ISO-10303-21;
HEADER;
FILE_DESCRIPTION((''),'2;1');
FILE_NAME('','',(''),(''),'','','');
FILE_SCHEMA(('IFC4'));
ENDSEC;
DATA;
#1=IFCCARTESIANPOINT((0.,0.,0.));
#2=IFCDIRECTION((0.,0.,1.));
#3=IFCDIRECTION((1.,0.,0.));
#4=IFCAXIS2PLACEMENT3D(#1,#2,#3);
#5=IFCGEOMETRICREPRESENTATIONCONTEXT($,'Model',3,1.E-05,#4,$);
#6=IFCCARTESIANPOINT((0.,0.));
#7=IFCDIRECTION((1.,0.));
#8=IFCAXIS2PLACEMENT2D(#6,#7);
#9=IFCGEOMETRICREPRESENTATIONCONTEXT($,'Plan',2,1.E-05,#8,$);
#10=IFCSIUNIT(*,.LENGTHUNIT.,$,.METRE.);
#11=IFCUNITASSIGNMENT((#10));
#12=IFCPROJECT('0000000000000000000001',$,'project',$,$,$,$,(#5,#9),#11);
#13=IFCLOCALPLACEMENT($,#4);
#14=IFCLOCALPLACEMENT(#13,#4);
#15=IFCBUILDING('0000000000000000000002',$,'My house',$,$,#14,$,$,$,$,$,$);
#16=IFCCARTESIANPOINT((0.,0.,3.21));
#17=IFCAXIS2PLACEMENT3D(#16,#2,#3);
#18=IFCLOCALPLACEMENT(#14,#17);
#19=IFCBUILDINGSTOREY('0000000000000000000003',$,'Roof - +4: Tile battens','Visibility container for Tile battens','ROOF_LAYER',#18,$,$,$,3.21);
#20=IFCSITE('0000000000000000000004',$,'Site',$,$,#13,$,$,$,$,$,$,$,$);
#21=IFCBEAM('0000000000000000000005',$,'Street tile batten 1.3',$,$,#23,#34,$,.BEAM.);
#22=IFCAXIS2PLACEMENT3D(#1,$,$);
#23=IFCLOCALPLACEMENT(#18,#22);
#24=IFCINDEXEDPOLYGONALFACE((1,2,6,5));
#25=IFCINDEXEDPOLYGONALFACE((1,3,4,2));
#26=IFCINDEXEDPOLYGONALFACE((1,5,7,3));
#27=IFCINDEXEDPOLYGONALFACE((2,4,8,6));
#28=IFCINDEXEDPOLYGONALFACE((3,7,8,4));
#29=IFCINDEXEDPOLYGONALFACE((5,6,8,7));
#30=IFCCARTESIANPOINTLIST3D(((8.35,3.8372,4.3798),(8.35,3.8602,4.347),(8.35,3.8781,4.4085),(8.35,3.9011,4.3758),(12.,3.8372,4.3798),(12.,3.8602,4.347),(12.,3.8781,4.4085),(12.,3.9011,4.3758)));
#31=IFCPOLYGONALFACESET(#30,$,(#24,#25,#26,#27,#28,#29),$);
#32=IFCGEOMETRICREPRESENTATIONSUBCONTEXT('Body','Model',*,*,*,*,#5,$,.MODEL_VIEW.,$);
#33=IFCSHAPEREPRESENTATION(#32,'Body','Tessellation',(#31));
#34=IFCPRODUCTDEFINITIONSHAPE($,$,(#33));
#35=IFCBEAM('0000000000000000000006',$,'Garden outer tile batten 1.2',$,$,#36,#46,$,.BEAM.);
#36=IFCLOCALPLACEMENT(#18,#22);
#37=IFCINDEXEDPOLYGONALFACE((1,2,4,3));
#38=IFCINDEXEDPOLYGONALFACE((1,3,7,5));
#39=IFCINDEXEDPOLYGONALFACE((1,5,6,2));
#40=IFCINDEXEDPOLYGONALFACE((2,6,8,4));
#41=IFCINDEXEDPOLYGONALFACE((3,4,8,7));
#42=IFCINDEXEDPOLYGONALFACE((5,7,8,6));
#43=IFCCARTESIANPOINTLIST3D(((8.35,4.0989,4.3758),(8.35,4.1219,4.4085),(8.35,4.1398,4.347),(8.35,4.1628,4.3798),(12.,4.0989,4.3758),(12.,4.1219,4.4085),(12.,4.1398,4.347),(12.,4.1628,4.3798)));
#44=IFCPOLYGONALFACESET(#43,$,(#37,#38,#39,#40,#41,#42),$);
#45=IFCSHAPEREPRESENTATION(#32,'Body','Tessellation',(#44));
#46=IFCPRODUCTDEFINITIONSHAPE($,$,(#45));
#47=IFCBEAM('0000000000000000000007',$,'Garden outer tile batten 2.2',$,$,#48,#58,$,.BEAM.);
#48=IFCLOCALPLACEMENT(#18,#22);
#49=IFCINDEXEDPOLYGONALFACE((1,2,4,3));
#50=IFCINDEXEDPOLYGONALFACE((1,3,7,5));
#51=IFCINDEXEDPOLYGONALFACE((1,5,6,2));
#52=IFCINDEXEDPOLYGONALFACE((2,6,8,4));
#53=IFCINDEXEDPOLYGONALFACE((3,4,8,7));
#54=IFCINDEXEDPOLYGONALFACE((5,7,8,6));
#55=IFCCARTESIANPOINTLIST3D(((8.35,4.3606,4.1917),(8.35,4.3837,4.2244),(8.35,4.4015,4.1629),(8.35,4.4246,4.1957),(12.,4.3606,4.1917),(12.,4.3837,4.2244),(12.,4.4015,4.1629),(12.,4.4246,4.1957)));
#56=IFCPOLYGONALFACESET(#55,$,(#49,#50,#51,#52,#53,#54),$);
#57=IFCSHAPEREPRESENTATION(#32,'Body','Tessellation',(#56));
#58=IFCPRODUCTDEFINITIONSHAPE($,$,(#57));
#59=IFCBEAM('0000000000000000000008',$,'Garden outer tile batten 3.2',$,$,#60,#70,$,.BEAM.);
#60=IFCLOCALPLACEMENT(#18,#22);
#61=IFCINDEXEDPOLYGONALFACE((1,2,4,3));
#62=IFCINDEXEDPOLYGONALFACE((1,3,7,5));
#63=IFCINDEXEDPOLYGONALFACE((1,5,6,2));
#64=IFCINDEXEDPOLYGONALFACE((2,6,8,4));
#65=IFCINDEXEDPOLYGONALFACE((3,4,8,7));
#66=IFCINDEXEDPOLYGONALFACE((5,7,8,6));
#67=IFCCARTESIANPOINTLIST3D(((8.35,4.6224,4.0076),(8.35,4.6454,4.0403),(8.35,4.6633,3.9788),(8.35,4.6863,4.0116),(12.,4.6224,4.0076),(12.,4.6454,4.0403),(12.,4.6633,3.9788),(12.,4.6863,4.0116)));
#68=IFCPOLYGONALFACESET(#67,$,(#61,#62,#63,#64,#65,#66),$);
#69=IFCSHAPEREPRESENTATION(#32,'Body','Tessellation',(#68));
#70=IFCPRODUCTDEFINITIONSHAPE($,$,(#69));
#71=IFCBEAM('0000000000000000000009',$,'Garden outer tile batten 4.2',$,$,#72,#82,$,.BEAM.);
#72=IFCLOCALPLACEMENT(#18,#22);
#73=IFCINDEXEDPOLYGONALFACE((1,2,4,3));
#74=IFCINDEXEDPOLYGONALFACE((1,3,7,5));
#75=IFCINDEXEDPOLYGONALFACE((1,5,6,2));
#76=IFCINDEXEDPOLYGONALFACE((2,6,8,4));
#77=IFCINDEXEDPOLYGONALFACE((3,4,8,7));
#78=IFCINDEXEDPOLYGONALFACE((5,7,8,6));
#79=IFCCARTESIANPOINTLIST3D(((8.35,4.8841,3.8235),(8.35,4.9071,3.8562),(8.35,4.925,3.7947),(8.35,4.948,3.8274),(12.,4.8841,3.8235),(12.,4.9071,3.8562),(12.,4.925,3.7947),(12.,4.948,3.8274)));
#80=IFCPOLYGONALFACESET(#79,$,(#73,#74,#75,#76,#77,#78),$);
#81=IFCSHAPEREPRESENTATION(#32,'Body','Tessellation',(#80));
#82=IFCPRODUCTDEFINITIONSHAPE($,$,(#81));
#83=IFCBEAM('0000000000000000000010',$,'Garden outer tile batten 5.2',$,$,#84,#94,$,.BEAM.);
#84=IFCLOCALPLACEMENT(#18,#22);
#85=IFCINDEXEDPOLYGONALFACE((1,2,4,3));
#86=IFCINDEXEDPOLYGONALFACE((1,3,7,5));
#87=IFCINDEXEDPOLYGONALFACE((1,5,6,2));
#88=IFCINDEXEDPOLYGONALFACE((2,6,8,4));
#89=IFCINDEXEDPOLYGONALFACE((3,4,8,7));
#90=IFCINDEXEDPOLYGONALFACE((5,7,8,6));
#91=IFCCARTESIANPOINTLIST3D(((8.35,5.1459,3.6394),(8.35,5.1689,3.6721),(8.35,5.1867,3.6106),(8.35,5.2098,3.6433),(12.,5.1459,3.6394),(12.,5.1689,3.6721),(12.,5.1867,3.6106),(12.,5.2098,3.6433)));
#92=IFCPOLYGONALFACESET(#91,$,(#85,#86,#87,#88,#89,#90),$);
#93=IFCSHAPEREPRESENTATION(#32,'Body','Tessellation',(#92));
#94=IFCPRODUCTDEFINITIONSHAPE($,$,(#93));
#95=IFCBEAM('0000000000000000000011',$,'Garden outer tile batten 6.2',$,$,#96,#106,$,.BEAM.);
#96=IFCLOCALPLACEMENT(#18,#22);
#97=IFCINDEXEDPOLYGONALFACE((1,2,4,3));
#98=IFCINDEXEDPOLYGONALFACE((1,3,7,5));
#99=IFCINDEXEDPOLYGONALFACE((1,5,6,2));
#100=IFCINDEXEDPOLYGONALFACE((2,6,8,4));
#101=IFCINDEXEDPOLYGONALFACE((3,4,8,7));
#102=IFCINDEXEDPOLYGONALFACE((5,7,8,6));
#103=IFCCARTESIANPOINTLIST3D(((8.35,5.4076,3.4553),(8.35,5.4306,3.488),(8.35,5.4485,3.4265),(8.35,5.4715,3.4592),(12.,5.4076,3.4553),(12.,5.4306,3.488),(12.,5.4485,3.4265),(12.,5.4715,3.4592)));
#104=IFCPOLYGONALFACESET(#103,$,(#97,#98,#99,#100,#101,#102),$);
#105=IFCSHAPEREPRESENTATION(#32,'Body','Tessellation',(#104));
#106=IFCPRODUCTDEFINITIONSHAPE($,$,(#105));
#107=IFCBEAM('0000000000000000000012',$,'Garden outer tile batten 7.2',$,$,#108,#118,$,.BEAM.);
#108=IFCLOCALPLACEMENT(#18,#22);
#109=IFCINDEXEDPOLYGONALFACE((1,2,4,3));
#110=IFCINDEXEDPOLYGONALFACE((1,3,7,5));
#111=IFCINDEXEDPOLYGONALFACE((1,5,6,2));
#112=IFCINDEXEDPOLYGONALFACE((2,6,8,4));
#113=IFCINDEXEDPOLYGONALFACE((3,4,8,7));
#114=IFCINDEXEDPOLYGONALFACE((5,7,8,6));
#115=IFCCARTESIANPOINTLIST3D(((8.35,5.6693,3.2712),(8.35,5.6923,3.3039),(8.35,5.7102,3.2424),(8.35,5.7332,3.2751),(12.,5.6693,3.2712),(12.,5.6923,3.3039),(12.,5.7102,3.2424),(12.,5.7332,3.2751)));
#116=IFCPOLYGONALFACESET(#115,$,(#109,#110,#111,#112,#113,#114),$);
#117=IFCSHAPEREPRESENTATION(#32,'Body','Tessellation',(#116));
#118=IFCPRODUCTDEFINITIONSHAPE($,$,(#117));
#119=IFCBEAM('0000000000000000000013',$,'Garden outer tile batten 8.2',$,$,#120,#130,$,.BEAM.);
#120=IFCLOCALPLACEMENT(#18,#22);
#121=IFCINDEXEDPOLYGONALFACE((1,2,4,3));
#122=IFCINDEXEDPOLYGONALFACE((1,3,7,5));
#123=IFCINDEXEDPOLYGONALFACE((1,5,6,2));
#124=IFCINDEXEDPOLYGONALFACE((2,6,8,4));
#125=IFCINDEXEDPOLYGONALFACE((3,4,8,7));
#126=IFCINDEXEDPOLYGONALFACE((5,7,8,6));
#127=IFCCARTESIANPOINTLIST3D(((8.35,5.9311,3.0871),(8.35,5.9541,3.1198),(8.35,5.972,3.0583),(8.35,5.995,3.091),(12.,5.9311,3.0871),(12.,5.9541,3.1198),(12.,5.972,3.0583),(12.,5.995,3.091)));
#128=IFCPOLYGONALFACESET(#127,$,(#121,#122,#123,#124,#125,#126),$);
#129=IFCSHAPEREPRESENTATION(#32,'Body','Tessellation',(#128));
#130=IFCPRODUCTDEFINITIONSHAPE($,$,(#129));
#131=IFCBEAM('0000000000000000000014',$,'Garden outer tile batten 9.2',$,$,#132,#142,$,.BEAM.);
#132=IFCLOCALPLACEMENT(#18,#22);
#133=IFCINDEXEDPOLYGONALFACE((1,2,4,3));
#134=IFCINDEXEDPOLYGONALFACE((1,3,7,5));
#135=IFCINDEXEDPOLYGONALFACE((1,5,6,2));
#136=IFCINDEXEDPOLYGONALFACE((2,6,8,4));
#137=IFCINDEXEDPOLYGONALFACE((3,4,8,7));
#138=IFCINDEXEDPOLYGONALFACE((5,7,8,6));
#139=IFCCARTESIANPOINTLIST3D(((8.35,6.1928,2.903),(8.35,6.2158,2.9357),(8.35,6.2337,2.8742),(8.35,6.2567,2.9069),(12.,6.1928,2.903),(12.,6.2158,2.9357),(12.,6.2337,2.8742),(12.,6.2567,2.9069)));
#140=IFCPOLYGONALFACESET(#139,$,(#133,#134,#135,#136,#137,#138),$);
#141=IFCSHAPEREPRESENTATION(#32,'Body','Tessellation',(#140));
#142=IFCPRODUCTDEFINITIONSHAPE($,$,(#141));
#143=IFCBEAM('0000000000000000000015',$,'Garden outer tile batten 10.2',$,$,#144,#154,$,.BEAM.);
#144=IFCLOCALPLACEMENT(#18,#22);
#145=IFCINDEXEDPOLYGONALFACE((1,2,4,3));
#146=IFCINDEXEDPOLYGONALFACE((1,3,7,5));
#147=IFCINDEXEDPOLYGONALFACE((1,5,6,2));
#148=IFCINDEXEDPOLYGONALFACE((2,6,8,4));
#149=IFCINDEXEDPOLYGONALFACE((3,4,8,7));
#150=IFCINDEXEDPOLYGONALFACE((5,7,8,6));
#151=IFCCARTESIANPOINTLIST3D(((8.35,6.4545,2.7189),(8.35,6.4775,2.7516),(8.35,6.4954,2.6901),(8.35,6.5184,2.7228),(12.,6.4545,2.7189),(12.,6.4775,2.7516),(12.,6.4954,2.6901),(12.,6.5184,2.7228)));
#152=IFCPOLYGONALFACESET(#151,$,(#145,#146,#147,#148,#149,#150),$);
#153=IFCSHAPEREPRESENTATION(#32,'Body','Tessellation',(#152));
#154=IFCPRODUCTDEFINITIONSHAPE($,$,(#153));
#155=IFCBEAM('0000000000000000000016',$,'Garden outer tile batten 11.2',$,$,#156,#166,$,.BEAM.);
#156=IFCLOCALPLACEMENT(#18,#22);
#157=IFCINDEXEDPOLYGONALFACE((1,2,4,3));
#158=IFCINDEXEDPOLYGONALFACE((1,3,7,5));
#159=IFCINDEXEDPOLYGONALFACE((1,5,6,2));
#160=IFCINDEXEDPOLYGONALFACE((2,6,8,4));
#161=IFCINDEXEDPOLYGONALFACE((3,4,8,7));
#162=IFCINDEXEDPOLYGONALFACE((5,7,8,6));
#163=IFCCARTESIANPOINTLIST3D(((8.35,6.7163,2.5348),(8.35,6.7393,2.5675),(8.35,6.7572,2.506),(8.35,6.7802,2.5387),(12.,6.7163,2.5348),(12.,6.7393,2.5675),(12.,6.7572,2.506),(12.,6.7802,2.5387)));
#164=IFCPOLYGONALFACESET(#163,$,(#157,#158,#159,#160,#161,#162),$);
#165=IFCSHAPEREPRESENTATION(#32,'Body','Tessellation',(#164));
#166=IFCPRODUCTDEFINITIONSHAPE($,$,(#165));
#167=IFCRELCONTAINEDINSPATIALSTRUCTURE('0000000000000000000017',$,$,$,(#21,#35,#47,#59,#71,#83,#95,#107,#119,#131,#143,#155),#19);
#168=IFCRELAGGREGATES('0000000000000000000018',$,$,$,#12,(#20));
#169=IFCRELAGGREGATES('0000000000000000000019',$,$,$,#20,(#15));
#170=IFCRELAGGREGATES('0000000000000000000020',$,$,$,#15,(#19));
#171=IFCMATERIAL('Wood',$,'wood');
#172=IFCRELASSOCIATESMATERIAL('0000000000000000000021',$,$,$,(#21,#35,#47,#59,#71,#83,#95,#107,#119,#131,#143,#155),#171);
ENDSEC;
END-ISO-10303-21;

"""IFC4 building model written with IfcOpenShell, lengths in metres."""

from ifc_helpers import new_model, si_unit, frame, origin_with_axes, origin_2d_with_axis, place, context, subcontext, project, spatial, rectangle, extrude, clip, halfspace, material, element, save


model = new_model("IFC4")

# Units and contexts
model_context = context("Model", 3, precision=1e-05, world=origin_with_axes())
plan_context = context("Plan", 2, precision=1e-05, world=origin_2d_with_axis())
body_context = subcontext(model_context, "Body", "Model", "MODEL_VIEW")
ifc_project = project(units=[si_unit("LENGTHUNIT", "METRE")], contexts=[model_context, plan_context])

# Site, building, storey
site_placement = place(None, origin_with_axes())
site = spatial("IfcSite", under=ifc_project, at=site_placement, Name="Site")
building_placement = place(site_placement, origin_with_axes())
building = spatial("IfcBuilding", under=site, at=building_placement, Name="My house")
storey_placement = place(building_placement, frame((0.0, 0.0, 3.21), z_axis=(0.0, 0.0, 1.0), x_axis=(1.0, 0.0, 0.0)))
storey = spatial("IfcBuildingStorey", under=building, at=storey_placement, Name="Roof - +4: Tile battens", Description="Visibility container for Tile battens", ObjectType="ROOF_LAYER", Elevation=3.21)

# Beams
ifc_material = material(Name="Wood", Category="wood")
beam_1_placement = place(storey_placement, frame((8.35, 3.8691, 4.3778), z_axis=(0.0, -0.575329, 0.817922), x_axis=(1.0, 0.0, 0.0)))
element("IfcBeam", 1, at=beam_1_placement, inside=storey, material=ifc_material, Name="Street tile batten 1.3", PredefinedType="BEAM", context=body_context, shape_type="Clipping", body=[
    clip(clip(extrude(rectangle(XDim=0.05, YDim=0.04), frame((0.0, 0.0, 0.0), z_axis=(1.0, 0.0, 0.0), x_axis=(0.0, 1.0, 0.0)), (0.0, 0.0, 1.0), 3.65), halfspace(frame((-8.35, -4.2584, -6.2815), z_axis=(0.0, 0.817922, -0.575329), x_axis=(1.0, 0.0, 0.0)), False)), halfspace(frame((-8.35, -7.8573, -3.7501), z_axis=(0.0, -0.817922, 0.575329), x_axis=(-1.0, 0.0, 0.0)), False)),
])
beam_2_placement = place(storey_placement, frame((8.35, 4.1309, 4.3778), z_axis=(0.0, 0.575329, 0.817922), x_axis=(1.0, 0.0, 0.0)))
element("IfcBeam", 2, at=beam_2_placement, inside=storey, material=ifc_material, Name="Garden outer tile batten 1.2", PredefinedType="BEAM", context=body_context, shape_type="Clipping", body=[
    clip(clip(extrude(rectangle(XDim=0.05, YDim=0.04), frame((0.0, 0.0, 0.0), z_axis=(1.0, 0.0, 0.0), x_axis=(0.0, 1.0, 0.0)), (0.0, 0.0, 1.0), 3.65), halfspace(frame((-8.35, 4.2584, -6.2815), z_axis=(0.0, -0.817922, -0.575329), x_axis=(-1.0, 0.0, 0.0)), False)), halfspace(frame((-8.35, 7.8573, -3.7501), z_axis=(0.0, 0.817922, 0.575329), x_axis=(1.0, 0.0, 0.0)), False)),
])
beam_3_placement = place(storey_placement, frame((8.35, 4.3926, 4.1937), z_axis=(0.0, 0.575329, 0.817922), x_axis=(1.0, 0.0, 0.0)))
element("IfcBeam", 3, at=beam_3_placement, inside=storey, material=ifc_material, Name="Garden outer tile batten 2.2", PredefinedType="BEAM", context=body_context, shape_type="Clipping", body=[
    clip(clip(extrude(rectangle(XDim=0.05, YDim=0.04), frame((0.0, 0.0, 0.0), z_axis=(1.0, 0.0, 0.0), x_axis=(0.0, 1.0, 0.0)), (0.0, 0.0, 1.0), 3.65), halfspace(frame((-8.35, 3.9384, -6.2815), z_axis=(0.0, -0.817922, -0.575329), x_axis=(-1.0, 0.0, 0.0)), False)), halfspace(frame((-8.35, 7.5373, -3.7501), z_axis=(0.0, 0.817922, 0.575329), x_axis=(1.0, 0.0, 0.0)), False)),
])
beam_4_placement = place(storey_placement, frame((8.35, 4.6543, 4.0096), z_axis=(0.0, 0.575329, 0.817922), x_axis=(1.0, 0.0, 0.0)))
element("IfcBeam", 4, at=beam_4_placement, inside=storey, material=ifc_material, Name="Garden outer tile batten 3.2", PredefinedType="BEAM", context=body_context, shape_type="Clipping", body=[
    clip(clip(extrude(rectangle(XDim=0.05, YDim=0.04), frame((0.0, 0.0, 0.0), z_axis=(1.0, 0.0, 0.0), x_axis=(0.0, 1.0, 0.0)), (0.0, 0.0, 1.0), 3.65), halfspace(frame((-8.35, 3.6184, -6.2815), z_axis=(0.0, -0.817922, -0.575329), x_axis=(-1.0, 0.0, 0.0)), False)), halfspace(frame((-8.35, 7.2173, -3.7501), z_axis=(0.0, 0.817922, 0.575329), x_axis=(1.0, 0.0, 0.0)), False)),
])
beam_5_placement = place(storey_placement, frame((8.35, 4.9161, 3.8255), z_axis=(0.0, 0.575329, 0.817922), x_axis=(1.0, 0.0, 0.0)))
element("IfcBeam", 5, at=beam_5_placement, inside=storey, material=ifc_material, Name="Garden outer tile batten 4.2", PredefinedType="BEAM", context=body_context, shape_type="Clipping", body=[
    clip(clip(extrude(rectangle(XDim=0.05, YDim=0.04), frame((0.0, 0.0, 0.0), z_axis=(1.0, 0.0, 0.0), x_axis=(0.0, 1.0, 0.0)), (0.0, 0.0, 1.0), 3.65), halfspace(frame((-8.35, 3.2984, -6.2815), z_axis=(0.0, -0.817922, -0.575329), x_axis=(-1.0, 0.0, 0.0)), False)), halfspace(frame((-8.35, 6.8973, -3.7501), z_axis=(0.0, 0.817922, 0.575329), x_axis=(1.0, 0.0, 0.0)), False)),
])
beam_6_placement = place(storey_placement, frame((8.35, 5.1778, 3.6414), z_axis=(0.0, 0.575329, 0.817922), x_axis=(1.0, 0.0, 0.0)))
element("IfcBeam", 6, at=beam_6_placement, inside=storey, material=ifc_material, Name="Garden outer tile batten 5.2", PredefinedType="BEAM", context=body_context, shape_type="Clipping", body=[
    clip(clip(extrude(rectangle(XDim=0.05, YDim=0.04), frame((0.0, 0.0, 0.0), z_axis=(1.0, 0.0, 0.0), x_axis=(0.0, 1.0, 0.0)), (0.0, 0.0, 1.0), 3.65), halfspace(frame((-8.35, 2.9784, -6.2815), z_axis=(0.0, -0.817922, -0.575329), x_axis=(-1.0, 0.0, 0.0)), False)), halfspace(frame((-8.35, 6.5773, -3.7501), z_axis=(0.0, 0.817922, 0.575329), x_axis=(1.0, 0.0, 0.0)), False)),
])
beam_7_placement = place(storey_placement, frame((8.35, 5.4395, 3.4573), z_axis=(0.0, 0.575329, 0.817922), x_axis=(1.0, 0.0, 0.0)))
element("IfcBeam", 7, at=beam_7_placement, inside=storey, material=ifc_material, Name="Garden outer tile batten 6.2", PredefinedType="BEAM", context=body_context, shape_type="Clipping", body=[
    clip(clip(extrude(rectangle(XDim=0.05, YDim=0.04), frame((0.0, 0.0, 0.0), z_axis=(1.0, 0.0, 0.0), x_axis=(0.0, 1.0, 0.0)), (0.0, 0.0, 1.0), 3.65), halfspace(frame((-8.35, 2.6584, -6.2815), z_axis=(0.0, -0.817922, -0.575329), x_axis=(-1.0, 0.0, 0.0)), False)), halfspace(frame((-8.35, 6.2573, -3.7501), z_axis=(0.0, 0.817922, 0.575329), x_axis=(1.0, 0.0, 0.0)), False)),
])
beam_8_placement = place(storey_placement, frame((8.35, 5.7013, 3.2732), z_axis=(0.0, 0.575329, 0.817922), x_axis=(1.0, 0.0, 0.0)))
element("IfcBeam", 8, at=beam_8_placement, inside=storey, material=ifc_material, Name="Garden outer tile batten 7.2", PredefinedType="BEAM", context=body_context, shape_type="Clipping", body=[
    clip(clip(extrude(rectangle(XDim=0.05, YDim=0.04), frame((0.0, 0.0, 0.0), z_axis=(1.0, 0.0, 0.0), x_axis=(0.0, 1.0, 0.0)), (0.0, 0.0, 1.0), 3.65), halfspace(frame((-8.35, 2.3384, -6.2815), z_axis=(0.0, -0.817922, -0.575329), x_axis=(-1.0, 0.0, 0.0)), False)), halfspace(frame((-8.35, 5.9373, -3.7501), z_axis=(0.0, 0.817922, 0.575329), x_axis=(1.0, 0.0, 0.0)), False)),
])
beam_9_placement = place(storey_placement, frame((8.35, 5.963, 3.089), z_axis=(0.0, 0.575329, 0.817922), x_axis=(1.0, 0.0, 0.0)))
element("IfcBeam", 9, at=beam_9_placement, inside=storey, material=ifc_material, Name="Garden outer tile batten 8.2", PredefinedType="BEAM", context=body_context, shape_type="Clipping", body=[
    clip(clip(extrude(rectangle(XDim=0.05, YDim=0.04), frame((0.0, 0.0, 0.0), z_axis=(1.0, 0.0, 0.0), x_axis=(0.0, 1.0, 0.0)), (0.0, 0.0, 1.0), 3.65), halfspace(frame((-8.35, 2.0184, -6.2815), z_axis=(0.0, -0.817922, -0.575329), x_axis=(-1.0, 0.0, 0.0)), False)), halfspace(frame((-8.35, 5.6173, -3.7501), z_axis=(0.0, 0.817922, 0.575329), x_axis=(1.0, 0.0, 0.0)), False)),
])
beam_10_placement = place(storey_placement, frame((8.35, 6.2247, 2.9049), z_axis=(0.0, 0.575329, 0.817922), x_axis=(1.0, 0.0, 0.0)))
element("IfcBeam", 10, at=beam_10_placement, inside=storey, material=ifc_material, Name="Garden outer tile batten 9.2", PredefinedType="BEAM", context=body_context, shape_type="Clipping", body=[
    clip(clip(extrude(rectangle(XDim=0.05, YDim=0.04), frame((0.0, 0.0, 0.0), z_axis=(1.0, 0.0, 0.0), x_axis=(0.0, 1.0, 0.0)), (0.0, 0.0, 1.0), 3.65), halfspace(frame((-8.35, 1.6984, -6.2815), z_axis=(0.0, -0.817922, -0.575329), x_axis=(-1.0, 0.0, 0.0)), False)), halfspace(frame((-8.35, 5.2973, -3.7501), z_axis=(0.0, 0.817922, 0.575329), x_axis=(1.0, 0.0, 0.0)), False)),
])
beam_11_placement = place(storey_placement, frame((8.35, 6.4865, 2.7208), z_axis=(0.0, 0.575329, 0.817922), x_axis=(1.0, 0.0, 0.0)))
element("IfcBeam", 11, at=beam_11_placement, inside=storey, material=ifc_material, Name="Garden outer tile batten 10.2", PredefinedType="BEAM", context=body_context, shape_type="Clipping", body=[
    clip(clip(extrude(rectangle(XDim=0.05, YDim=0.04), frame((0.0, 0.0, 0.0), z_axis=(1.0, 0.0, 0.0), x_axis=(0.0, 1.0, 0.0)), (0.0, 0.0, 1.0), 3.65), halfspace(frame((-8.35, 1.3784, -6.2815), z_axis=(0.0, -0.817922, -0.575329), x_axis=(-1.0, 0.0, 0.0)), False)), halfspace(frame((-8.35, 4.9773, -3.7501), z_axis=(0.0, 0.817922, 0.575329), x_axis=(1.0, 0.0, 0.0)), False)),
])
beam_12_placement = place(storey_placement, frame((8.35, 6.7482, 2.5367), z_axis=(0.0, 0.575329, 0.817922), x_axis=(1.0, 0.0, 0.0)))
element("IfcBeam", 12, at=beam_12_placement, inside=storey, material=ifc_material, Name="Garden outer tile batten 11.2", PredefinedType="BEAM", context=body_context, shape_type="Clipping", body=[
    clip(clip(extrude(rectangle(XDim=0.05, YDim=0.04), frame((0.0, 0.0, 0.0), z_axis=(1.0, 0.0, 0.0), x_axis=(0.0, 1.0, 0.0)), (0.0, 0.0, 1.0), 3.65), halfspace(frame((-8.35, 1.0584, -6.2815), z_axis=(0.0, -0.817922, -0.575329), x_axis=(-1.0, 0.0, 0.0)), False)), halfspace(frame((-8.35, 4.6573, -3.7501), z_axis=(0.0, 0.817922, 0.575329), x_axis=(1.0, 0.0, 0.0)), False)),
])

save(model, "model.ifc")
